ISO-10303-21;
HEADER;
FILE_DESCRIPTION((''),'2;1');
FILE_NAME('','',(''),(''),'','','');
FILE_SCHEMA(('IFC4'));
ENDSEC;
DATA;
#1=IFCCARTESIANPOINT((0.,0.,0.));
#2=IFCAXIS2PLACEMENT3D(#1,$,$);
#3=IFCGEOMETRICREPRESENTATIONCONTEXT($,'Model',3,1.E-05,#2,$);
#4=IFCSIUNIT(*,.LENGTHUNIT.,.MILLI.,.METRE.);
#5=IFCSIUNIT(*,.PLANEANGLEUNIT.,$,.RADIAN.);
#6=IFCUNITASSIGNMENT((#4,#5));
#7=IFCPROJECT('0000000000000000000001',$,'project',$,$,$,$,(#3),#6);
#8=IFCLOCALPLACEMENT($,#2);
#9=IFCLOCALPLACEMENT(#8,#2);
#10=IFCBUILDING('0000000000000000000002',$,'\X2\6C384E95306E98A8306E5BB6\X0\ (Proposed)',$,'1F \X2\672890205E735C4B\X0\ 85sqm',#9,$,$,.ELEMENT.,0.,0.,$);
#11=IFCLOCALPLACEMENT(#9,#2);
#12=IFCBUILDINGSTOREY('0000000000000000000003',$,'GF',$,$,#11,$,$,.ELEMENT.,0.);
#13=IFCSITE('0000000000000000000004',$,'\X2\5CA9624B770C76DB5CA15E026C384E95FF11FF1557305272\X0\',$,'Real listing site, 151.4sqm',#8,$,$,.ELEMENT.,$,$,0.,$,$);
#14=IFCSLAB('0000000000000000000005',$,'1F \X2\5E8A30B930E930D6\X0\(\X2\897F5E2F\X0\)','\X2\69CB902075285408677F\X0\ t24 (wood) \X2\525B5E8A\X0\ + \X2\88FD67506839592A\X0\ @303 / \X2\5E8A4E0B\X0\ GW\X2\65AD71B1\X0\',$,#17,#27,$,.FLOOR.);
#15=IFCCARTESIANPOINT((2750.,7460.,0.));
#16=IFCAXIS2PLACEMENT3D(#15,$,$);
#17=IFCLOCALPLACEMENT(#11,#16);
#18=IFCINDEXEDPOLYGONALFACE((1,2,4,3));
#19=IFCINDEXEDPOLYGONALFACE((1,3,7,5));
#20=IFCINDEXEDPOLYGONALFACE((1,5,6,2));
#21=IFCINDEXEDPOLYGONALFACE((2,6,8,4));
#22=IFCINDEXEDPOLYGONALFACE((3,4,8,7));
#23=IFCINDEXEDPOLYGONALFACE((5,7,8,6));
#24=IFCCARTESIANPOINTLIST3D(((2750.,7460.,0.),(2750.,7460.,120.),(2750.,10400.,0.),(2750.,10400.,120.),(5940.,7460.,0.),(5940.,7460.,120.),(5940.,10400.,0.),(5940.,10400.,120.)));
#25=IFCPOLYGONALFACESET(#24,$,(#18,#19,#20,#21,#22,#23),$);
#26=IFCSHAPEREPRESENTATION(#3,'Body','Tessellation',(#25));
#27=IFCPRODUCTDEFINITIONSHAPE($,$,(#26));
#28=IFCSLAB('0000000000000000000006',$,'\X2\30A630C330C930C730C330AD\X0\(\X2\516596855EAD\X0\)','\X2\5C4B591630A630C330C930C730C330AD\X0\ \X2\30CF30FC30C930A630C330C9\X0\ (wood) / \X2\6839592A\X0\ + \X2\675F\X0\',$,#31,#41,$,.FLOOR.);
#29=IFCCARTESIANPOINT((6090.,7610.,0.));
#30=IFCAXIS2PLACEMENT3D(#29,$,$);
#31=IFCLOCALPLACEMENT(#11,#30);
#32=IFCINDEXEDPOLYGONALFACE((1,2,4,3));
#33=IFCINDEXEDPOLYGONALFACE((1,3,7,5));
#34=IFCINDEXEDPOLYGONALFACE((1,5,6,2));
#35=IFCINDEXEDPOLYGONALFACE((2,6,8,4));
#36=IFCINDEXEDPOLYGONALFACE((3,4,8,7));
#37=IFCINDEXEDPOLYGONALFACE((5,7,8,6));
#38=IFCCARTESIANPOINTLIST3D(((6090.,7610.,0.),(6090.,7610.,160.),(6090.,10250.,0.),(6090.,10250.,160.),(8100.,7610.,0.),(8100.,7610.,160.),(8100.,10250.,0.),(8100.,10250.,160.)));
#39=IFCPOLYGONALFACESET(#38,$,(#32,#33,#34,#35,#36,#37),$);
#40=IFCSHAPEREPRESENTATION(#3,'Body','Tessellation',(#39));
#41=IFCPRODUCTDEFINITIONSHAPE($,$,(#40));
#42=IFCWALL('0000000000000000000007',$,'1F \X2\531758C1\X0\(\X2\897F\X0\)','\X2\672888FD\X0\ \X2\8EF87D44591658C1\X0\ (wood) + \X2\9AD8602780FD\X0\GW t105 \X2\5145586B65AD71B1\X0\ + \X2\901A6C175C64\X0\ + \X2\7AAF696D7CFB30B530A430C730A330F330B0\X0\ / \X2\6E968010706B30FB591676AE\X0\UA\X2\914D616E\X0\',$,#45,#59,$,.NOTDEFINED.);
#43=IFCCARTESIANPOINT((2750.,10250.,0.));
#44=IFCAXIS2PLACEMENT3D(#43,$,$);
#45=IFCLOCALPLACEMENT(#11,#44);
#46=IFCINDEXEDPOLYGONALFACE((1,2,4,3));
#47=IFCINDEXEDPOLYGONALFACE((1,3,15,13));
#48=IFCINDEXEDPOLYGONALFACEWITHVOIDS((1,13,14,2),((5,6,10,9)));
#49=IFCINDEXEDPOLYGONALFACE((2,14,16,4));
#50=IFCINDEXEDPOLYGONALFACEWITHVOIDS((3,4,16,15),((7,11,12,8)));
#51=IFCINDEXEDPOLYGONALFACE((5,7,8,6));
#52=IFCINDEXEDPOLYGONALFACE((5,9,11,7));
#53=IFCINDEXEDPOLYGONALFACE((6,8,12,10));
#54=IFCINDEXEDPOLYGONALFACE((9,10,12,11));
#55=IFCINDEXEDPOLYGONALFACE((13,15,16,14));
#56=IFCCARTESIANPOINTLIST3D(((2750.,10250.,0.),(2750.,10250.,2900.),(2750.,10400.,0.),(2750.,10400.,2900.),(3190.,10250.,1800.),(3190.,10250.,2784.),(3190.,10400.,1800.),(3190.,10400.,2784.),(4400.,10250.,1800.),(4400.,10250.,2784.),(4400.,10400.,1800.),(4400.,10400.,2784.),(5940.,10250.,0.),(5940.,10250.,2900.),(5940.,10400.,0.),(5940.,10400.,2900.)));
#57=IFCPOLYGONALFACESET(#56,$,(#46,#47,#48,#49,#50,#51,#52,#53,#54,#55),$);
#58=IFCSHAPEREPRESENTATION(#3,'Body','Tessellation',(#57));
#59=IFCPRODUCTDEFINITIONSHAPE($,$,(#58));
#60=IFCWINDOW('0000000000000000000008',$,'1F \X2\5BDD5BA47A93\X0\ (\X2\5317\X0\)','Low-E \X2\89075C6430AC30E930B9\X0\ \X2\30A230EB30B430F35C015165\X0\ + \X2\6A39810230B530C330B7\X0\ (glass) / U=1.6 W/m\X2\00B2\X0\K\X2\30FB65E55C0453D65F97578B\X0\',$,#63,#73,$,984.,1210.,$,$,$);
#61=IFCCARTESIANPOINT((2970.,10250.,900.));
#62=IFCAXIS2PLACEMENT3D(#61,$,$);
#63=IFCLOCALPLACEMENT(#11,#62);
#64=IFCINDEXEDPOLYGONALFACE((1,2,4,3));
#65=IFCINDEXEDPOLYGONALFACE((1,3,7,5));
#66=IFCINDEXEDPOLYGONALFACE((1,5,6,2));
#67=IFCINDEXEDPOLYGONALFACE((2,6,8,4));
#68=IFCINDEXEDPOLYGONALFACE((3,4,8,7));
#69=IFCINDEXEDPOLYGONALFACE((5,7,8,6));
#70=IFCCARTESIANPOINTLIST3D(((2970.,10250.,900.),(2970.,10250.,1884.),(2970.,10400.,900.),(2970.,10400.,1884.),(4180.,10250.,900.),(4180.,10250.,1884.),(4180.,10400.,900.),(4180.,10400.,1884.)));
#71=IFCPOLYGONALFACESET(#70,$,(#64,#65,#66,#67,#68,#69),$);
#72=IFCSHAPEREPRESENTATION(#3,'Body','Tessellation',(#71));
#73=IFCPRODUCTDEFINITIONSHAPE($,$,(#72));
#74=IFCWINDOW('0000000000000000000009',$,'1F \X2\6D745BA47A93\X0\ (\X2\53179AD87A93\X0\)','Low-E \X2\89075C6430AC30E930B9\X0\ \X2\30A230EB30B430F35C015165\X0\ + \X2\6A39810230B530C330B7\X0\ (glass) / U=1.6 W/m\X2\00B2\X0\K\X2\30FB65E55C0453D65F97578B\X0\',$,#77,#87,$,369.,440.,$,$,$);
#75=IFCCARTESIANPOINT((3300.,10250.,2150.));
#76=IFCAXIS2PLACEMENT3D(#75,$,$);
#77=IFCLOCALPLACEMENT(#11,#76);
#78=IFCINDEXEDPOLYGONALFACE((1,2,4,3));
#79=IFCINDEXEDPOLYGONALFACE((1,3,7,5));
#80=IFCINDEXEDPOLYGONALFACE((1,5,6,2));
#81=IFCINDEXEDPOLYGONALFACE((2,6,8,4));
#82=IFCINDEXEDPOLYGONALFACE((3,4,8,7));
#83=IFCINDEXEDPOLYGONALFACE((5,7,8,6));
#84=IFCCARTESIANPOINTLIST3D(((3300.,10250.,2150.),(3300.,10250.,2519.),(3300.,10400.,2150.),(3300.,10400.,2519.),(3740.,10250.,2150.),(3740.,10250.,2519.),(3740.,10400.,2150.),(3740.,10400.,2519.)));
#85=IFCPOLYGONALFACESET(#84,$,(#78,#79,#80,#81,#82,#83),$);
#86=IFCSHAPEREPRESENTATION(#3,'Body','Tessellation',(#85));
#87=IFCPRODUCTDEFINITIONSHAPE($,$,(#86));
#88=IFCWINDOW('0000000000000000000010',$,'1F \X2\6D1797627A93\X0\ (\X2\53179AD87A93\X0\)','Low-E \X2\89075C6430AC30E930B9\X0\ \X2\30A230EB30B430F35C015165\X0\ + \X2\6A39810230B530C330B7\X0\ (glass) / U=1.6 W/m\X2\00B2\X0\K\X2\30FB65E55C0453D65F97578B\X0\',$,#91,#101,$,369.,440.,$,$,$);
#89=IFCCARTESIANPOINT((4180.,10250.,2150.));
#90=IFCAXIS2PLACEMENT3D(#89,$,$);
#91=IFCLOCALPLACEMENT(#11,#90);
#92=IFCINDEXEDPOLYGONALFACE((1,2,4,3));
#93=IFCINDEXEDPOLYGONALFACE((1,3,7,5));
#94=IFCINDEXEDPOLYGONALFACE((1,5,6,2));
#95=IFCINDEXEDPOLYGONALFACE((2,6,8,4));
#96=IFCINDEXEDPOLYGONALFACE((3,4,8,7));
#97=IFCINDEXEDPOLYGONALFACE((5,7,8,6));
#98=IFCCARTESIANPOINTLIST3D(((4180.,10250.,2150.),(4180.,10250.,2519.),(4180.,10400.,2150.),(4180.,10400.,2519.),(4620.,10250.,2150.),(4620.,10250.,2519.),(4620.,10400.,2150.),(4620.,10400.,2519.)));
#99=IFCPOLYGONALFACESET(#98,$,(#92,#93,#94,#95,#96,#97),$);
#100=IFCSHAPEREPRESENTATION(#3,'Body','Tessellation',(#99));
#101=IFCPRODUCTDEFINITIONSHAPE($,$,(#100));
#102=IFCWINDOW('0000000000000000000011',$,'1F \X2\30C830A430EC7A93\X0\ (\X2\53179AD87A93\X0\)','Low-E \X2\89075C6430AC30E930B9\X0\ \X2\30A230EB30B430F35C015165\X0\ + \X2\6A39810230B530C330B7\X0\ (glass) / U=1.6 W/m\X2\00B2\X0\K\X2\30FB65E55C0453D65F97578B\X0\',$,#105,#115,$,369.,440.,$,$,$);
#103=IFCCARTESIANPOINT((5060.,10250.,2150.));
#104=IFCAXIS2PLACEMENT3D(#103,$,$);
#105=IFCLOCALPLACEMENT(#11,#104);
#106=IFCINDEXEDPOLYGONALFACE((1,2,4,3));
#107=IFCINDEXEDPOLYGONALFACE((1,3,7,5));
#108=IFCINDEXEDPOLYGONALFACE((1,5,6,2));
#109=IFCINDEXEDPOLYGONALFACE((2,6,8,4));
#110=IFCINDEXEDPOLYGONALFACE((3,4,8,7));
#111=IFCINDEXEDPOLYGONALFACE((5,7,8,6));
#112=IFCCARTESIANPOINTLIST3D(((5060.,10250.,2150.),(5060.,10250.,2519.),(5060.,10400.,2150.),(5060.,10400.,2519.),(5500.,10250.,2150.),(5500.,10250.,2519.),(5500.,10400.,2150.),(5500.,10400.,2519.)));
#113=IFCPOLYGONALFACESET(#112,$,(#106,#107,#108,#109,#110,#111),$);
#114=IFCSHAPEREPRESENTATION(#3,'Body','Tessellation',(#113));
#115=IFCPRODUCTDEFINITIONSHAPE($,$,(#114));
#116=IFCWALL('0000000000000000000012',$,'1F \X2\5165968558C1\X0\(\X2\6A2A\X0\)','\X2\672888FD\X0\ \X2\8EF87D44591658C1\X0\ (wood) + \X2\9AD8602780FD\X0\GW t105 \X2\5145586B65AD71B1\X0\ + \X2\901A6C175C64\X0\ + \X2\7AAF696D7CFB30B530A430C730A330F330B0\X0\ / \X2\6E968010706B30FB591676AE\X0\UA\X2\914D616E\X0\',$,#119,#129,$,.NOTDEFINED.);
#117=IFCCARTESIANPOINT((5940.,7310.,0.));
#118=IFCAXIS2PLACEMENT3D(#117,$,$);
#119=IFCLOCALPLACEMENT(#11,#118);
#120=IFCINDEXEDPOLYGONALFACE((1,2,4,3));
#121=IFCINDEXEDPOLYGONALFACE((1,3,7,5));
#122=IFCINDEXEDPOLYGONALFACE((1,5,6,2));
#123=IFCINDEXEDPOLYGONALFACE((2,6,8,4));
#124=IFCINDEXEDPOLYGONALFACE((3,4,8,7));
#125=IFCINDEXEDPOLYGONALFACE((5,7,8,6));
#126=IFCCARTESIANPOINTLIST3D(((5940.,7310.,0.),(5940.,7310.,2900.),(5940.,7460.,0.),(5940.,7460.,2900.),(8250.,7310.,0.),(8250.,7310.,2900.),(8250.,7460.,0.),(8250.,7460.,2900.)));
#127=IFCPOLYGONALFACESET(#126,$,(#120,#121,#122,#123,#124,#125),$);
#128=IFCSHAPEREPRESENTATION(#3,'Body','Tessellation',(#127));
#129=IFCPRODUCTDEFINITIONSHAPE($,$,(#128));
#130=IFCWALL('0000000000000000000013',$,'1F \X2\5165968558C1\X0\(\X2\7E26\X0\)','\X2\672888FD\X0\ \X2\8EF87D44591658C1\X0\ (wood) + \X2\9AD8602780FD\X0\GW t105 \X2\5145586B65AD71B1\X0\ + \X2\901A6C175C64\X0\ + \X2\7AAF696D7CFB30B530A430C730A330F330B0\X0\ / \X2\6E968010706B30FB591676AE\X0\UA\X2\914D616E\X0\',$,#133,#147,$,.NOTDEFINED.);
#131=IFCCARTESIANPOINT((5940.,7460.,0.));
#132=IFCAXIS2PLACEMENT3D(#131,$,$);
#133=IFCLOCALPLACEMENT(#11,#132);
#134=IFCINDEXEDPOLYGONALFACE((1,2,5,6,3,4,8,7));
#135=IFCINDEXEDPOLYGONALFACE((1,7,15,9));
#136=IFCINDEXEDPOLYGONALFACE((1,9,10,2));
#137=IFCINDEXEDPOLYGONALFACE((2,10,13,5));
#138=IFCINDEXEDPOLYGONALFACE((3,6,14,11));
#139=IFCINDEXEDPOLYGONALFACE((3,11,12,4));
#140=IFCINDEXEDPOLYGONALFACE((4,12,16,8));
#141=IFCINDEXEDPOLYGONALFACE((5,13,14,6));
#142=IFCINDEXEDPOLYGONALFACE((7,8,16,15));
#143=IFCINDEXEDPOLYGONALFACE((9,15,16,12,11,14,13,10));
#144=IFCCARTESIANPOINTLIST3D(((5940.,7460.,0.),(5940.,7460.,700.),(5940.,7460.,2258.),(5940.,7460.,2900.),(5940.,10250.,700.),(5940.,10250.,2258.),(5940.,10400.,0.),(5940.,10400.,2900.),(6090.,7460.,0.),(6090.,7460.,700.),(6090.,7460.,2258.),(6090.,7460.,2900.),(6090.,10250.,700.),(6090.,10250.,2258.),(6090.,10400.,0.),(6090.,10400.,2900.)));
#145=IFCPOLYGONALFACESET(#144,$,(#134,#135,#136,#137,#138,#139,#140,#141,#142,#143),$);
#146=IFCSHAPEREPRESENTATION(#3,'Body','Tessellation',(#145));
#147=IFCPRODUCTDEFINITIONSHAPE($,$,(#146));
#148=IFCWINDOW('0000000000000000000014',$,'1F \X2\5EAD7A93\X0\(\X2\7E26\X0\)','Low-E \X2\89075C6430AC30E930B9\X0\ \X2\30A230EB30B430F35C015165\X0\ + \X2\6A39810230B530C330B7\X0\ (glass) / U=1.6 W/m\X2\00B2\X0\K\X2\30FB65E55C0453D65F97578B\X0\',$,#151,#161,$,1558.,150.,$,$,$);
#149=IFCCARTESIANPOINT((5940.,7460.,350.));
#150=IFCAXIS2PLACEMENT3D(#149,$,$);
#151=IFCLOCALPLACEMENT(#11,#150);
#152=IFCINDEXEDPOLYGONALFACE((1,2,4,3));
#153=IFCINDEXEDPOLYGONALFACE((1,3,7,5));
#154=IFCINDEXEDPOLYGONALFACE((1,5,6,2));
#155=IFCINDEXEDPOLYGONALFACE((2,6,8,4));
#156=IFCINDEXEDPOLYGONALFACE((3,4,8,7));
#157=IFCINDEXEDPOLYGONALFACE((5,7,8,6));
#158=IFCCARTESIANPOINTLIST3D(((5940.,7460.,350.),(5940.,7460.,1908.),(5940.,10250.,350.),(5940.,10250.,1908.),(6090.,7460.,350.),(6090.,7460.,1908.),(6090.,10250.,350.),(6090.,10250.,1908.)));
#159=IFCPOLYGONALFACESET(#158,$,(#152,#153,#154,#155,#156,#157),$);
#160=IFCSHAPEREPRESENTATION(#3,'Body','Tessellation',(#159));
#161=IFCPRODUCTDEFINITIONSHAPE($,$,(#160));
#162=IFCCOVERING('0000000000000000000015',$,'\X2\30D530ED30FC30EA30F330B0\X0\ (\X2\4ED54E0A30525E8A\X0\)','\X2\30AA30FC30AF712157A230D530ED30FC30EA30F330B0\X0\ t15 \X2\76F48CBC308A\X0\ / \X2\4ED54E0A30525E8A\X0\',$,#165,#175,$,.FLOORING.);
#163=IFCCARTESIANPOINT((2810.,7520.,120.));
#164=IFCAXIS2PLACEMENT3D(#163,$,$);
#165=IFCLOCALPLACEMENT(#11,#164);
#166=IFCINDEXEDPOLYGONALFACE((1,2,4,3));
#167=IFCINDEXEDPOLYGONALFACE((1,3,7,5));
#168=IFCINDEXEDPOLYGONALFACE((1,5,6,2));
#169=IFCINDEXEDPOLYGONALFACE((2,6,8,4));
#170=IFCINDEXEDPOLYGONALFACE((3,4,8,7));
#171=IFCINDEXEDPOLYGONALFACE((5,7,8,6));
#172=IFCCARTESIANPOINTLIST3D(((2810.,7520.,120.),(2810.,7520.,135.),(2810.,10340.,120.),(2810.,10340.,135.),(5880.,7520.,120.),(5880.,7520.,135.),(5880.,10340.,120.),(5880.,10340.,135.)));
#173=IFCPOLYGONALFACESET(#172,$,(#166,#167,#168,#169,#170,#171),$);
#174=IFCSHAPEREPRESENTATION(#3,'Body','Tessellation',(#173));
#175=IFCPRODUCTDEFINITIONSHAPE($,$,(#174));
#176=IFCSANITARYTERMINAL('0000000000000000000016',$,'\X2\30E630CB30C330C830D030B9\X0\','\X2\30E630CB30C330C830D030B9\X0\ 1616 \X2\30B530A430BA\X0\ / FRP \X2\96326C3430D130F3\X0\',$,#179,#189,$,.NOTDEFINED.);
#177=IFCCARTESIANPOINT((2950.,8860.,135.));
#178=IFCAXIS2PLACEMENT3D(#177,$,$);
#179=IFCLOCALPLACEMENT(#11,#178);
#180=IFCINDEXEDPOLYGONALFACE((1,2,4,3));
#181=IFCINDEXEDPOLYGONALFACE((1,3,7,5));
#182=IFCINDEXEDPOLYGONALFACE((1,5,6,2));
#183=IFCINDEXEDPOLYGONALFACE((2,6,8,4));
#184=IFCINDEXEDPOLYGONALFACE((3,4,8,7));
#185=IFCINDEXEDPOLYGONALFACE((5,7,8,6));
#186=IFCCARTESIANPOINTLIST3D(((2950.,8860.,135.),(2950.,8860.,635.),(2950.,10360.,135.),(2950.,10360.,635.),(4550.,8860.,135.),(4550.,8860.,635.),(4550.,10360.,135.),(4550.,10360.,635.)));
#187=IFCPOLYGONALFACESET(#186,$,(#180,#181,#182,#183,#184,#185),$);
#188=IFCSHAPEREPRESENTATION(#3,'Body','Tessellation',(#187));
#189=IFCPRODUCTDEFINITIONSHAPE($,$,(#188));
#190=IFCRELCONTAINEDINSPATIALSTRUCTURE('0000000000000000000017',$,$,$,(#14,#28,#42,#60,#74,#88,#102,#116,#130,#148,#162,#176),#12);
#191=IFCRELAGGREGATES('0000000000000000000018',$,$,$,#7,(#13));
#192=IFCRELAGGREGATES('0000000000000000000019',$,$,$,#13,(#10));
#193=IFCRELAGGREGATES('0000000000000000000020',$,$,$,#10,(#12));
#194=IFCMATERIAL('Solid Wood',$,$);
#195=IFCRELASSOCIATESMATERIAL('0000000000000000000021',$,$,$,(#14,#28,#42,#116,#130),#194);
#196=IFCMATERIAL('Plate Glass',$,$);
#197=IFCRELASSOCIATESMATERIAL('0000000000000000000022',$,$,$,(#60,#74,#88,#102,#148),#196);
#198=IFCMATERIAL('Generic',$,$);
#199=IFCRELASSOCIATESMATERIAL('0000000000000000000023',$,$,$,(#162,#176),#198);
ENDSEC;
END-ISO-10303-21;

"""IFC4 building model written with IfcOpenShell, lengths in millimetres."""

from ifc_helpers import new_model, si_unit, frame, frame_2d, origin, place, context, project, spatial, rectangle, extrude, material, element, fill, save


model = new_model("IFC4")

# Units and contexts
model_context = context("Model", 3, precision=1e-05, world=origin())
ifc_project = project(units=[si_unit("LENGTHUNIT", "METRE", prefix="MILLI"), si_unit("PLANEANGLEUNIT", "RADIAN")], contexts=[model_context])

# Site, building, storey
site_placement = place(None, origin())
site = spatial("IfcSite", under=ifc_project, at=site_placement, Name="岩手県盛岡市永井１５地割", ObjectType="Real listing site, 151.4sqm", CompositionType="ELEMENT", RefElevation=0.0)
building_placement = place(site_placement, origin())
building = spatial("IfcBuilding", under=site, at=building_placement, Name="永井の風の家 (Proposed)", ObjectType="1F 木造平屋 85sqm", CompositionType="ELEMENT", ElevationOfRefHeight=0.0, ElevationOfTerrain=0.0)
storey_placement = place(building_placement, origin())
storey = spatial("IfcBuildingStorey", under=building, at=storey_placement, Name="GF", CompositionType="ELEMENT", Elevation=0.0)

# Slabs
ifc_material_1 = material(Name="Solid Wood")
slab_1_placement = place(storey_placement, frame((2750.0, 7460.0, 0.0)))
element("IfcSlab", 1, at=slab_1_placement, inside=storey, material=ifc_material_1, Name="1F 床スラブ(西帯)", Description="構造用合板 t24 (wood) 剛床 + 製材根太 @303 / 床下 GW断熱", PredefinedType="FLOOR", context=model_context, shape_type="SweptSolid", body=[
    extrude(rectangle(XDim=3190.0, YDim=2940.0, at=frame_2d((1595.0, 1470.0))), frame((2750.0, 7460.0, 0.0)), (0.0, 0.0, 1.0), 120.0),
])
slab_2_placement = place(storey_placement, frame((6090.0, 7610.0, 0.0)))
element("IfcSlab", 2, at=slab_2_placement, inside=storey, material=ifc_material_1, Name="ウッドデッキ(入隅庭)", Description="屋外ウッドデッキ ハードウッド (wood) / 根太 + 束", PredefinedType="FLOOR", context=model_context, shape_type="SweptSolid", body=[
    extrude(rectangle(XDim=2010.0, YDim=2640.0, at=frame_2d((1005.0, 1320.0))), frame((6090.0, 7610.0, 0.0)), (0.0, 0.0, 1.0), 160.0),
])

# Wall, openings, windows
wall_1_placement = place(storey_placement, frame((2750.0, 10250.0, 0.0)))
wall_1 = element("IfcWall", 3, at=wall_1_placement, inside=storey, material=ifc_material_1, Name="1F 北壁(西)", Description="木製 軸組外壁 (wood) + 高性能GW t105 充填断熱 + 通気層 + 窯業系サイディング / 準耐火・外皮UA配慮", PredefinedType="NOTDEFINED", context=model_context, shape_type="SweptSolid", body=[
    extrude(rectangle(XDim=3190.0, YDim=150.0, at=frame_2d((1595.0, 75.0))), frame((2750.0, 10250.0, 0.0)), (0.0, 0.0, 1.0), 2900.0),
])
opening_1_placement = place(storey_placement, frame((2970.0, 10250.0, 900.0)))
opening_1 = element("IfcOpeningElement", 4, at=opening_1_placement, cuts=wall_1, PredefinedType="NOTDEFINED", context=model_context, shape_type="SweptSolid", body=[
    extrude(rectangle(XDim=1210.0, YDim=150.0, at=frame_2d((605.0, 75.0))), frame((2970.0, 10250.0, 900.0)), (0.0, 0.0, 1.0), 984.0),
])
opening_2_placement = place(storey_placement, frame((3300.0, 10250.0, 2150.0)))
opening_2 = element("IfcOpeningElement", 5, at=opening_2_placement, cuts=wall_1, PredefinedType="NOTDEFINED", context=model_context, shape_type="SweptSolid", body=[
    extrude(rectangle(XDim=440.0, YDim=150.0, at=frame_2d((220.0, 75.0))), frame((3300.0, 10250.0, 2150.0)), (0.0, 0.0, 1.0), 369.0),
])
opening_3_placement = place(storey_placement, frame((4180.0, 10250.0, 2150.0)))
opening_3 = element("IfcOpeningElement", 6, at=opening_3_placement, cuts=wall_1, PredefinedType="NOTDEFINED", context=model_context, shape_type="SweptSolid", body=[
    extrude(rectangle(XDim=440.0, YDim=150.0, at=frame_2d((220.0, 75.0))), frame((4180.0, 10250.0, 2150.0)), (0.0, 0.0, 1.0), 369.0),
])
opening_4_placement = place(storey_placement, frame((5060.0, 10250.0, 2150.0)))
opening_4 = element("IfcOpeningElement", 7, at=opening_4_placement, cuts=wall_1, PredefinedType="NOTDEFINED", context=model_context, shape_type="SweptSolid", body=[
    extrude(rectangle(XDim=440.0, YDim=150.0, at=frame_2d((220.0, 75.0))), frame((5060.0, 10250.0, 2150.0)), (0.0, 0.0, 1.0), 369.0),
])
ifc_material_2 = material(Name="Plate Glass")
window_1_placement = place(storey_placement, frame((2970.0, 10250.0, 900.0)))
window_1 = element("IfcWindow", 8, at=window_1_placement, inside=storey, material=ifc_material_2, Name="1F 寝室窓 (北)", Description="Low-E 複層ガラス アルゴン封入 + 樹脂サッシ (glass) / U=1.6 W/m²K・日射取得型", OverallHeight=984.0, OverallWidth=1210.0, context=model_context, shape_type="SweptSolid", body=[
    extrude(rectangle(XDim=1210.0, YDim=150.0, at=frame_2d((605.0, 75.0))), frame((2970.0, 10250.0, 900.0)), (0.0, 0.0, 1.0), 984.0),
])
fill(opening_1, window_1)
window_2_placement = place(storey_placement, frame((3300.0, 10250.0, 2150.0)))
window_2 = element("IfcWindow", 9, at=window_2_placement, inside=storey, material=ifc_material_2, Name="1F 浴室窓 (北高窓)", Description="Low-E 複層ガラス アルゴン封入 + 樹脂サッシ (glass) / U=1.6 W/m²K・日射取得型", OverallHeight=369.0, OverallWidth=440.0, context=model_context, shape_type="SweptSolid", body=[
    extrude(rectangle(XDim=440.0, YDim=150.0, at=frame_2d((220.0, 75.0))), frame((3300.0, 10250.0, 2150.0)), (0.0, 0.0, 1.0), 369.0),
])
fill(opening_2, window_2)
window_3_placement = place(storey_placement, frame((4180.0, 10250.0, 2150.0)))
window_3 = element("IfcWindow", 10, at=window_3_placement, inside=storey, material=ifc_material_2, Name="1F 洗面窓 (北高窓)", Description="Low-E 複層ガラス アルゴン封入 + 樹脂サッシ (glass) / U=1.6 W/m²K・日射取得型", OverallHeight=369.0, OverallWidth=440.0, context=model_context, shape_type="SweptSolid", body=[
    extrude(rectangle(XDim=440.0, YDim=150.0, at=frame_2d((220.0, 75.0))), frame((4180.0, 10250.0, 2150.0)), (0.0, 0.0, 1.0), 369.0),
])
fill(opening_3, window_3)
window_4_placement = place(storey_placement, frame((5060.0, 10250.0, 2150.0)))
window_4 = element("IfcWindow", 11, at=window_4_placement, inside=storey, material=ifc_material_2, Name="1F トイレ窓 (北高窓)", Description="Low-E 複層ガラス アルゴン封入 + 樹脂サッシ (glass) / U=1.6 W/m²K・日射取得型", OverallHeight=369.0, OverallWidth=440.0, context=model_context, shape_type="SweptSolid", body=[
    extrude(rectangle(XDim=440.0, YDim=150.0, at=frame_2d((220.0, 75.0))), frame((5060.0, 10250.0, 2150.0)), (0.0, 0.0, 1.0), 369.0),
])
fill(opening_4, window_4)

# Wall
wall_2_placement = place(storey_placement, frame((5940.0, 7310.0, 0.0)))
element("IfcWall", 12, at=wall_2_placement, inside=storey, material=ifc_material_1, Name="1F 入隅壁(横)", Description="木製 軸組外壁 (wood) + 高性能GW t105 充填断熱 + 通気層 + 窯業系サイディング / 準耐火・外皮UA配慮", PredefinedType="NOTDEFINED", context=model_context, shape_type="SweptSolid", body=[
    extrude(rectangle(XDim=2310.0, YDim=150.0, at=frame_2d((1155.0, 75.0))), frame((5940.0, 7310.0, 0.0)), (0.0, 0.0, 1.0), 2900.0),
])

# Wall, opening, window
wall_3_placement = place(storey_placement, frame((5940.0, 7460.0, 0.0)))
wall_3 = element("IfcWall", 13, at=wall_3_placement, inside=storey, material=ifc_material_1, Name="1F 入隅壁(縦)", Description="木製 軸組外壁 (wood) + 高性能GW t105 充填断熱 + 通気層 + 窯業系サイディング / 準耐火・外皮UA配慮", PredefinedType="NOTDEFINED", context=model_context, shape_type="SweptSolid", body=[
    extrude(rectangle(XDim=150.0, YDim=2940.0, at=frame_2d((75.0, 1470.0))), frame((5940.0, 7460.0, 0.0)), (0.0, 0.0, 1.0), 2900.0),
])
opening_5_placement = place(storey_placement, frame((5940.0, 7460.0, 350.0)))
opening_5 = element("IfcOpeningElement", 14, at=opening_5_placement, cuts=wall_3, PredefinedType="NOTDEFINED", context=model_context, shape_type="SweptSolid", body=[
    extrude(rectangle(XDim=150.0, YDim=2790.0, at=frame_2d((75.0, 1395.0))), frame((5940.0, 7460.0, 350.0)), (0.0, 0.0, 1.0), 1558.0),
])
window_5_placement = place(storey_placement, frame((5940.0, 7460.0, 350.0)))
window_5 = element("IfcWindow", 15, at=window_5_placement, inside=storey, material=ifc_material_2, Name="1F 庭窓(縦)", Description="Low-E 複層ガラス アルゴン封入 + 樹脂サッシ (glass) / U=1.6 W/m²K・日射取得型", OverallHeight=1558.0, OverallWidth=150.0, context=model_context, shape_type="SweptSolid", body=[
    extrude(rectangle(XDim=150.0, YDim=2790.0, at=frame_2d((75.0, 1395.0))), frame((5940.0, 7460.0, 350.0)), (0.0, 0.0, 1.0), 1558.0),
])
fill(opening_5, window_5)

# Covering
ifc_material_3 = material(Name="Generic")
covering_placement = place(storey_placement, frame((2810.0, 7520.0, 120.0)))
element("IfcCovering", 16, at=covering_placement, inside=storey, material=ifc_material_3, Name="フローリング (仕上げ床)", Description="オーク無垢フローリング t15 直貼り / 仕上げ床", PredefinedType="FLOORING", context=model_context, shape_type="SweptSolid", body=[
    extrude(rectangle(XDim=3070.0, YDim=2820.0, at=frame_2d((1535.0, 1410.0))), frame((2810.0, 7520.0, 120.0)), (0.0, 0.0, 1.0), 15.0),
])

# Sanitary terminal
sanitary_terminal_1_placement = place(storey_placement, frame((2950.0, 8860.0, 135.0)))
element("IfcSanitaryTerminal", 17, at=sanitary_terminal_1_placement, inside=storey, material=ifc_material_3, Name="ユニットバス", Description="ユニットバス 1616 サイズ / FRP 防水パン", PredefinedType="NOTDEFINED", context=model_context, shape_type="SweptSolid", body=[
    extrude(rectangle(XDim=1600.0, YDim=1500.0, at=frame_2d((800.0, 750.0))), frame((2950.0, 8860.0, 135.0)), (0.0, 0.0, 1.0), 500.0),
])

save(model, "model.ifc")
